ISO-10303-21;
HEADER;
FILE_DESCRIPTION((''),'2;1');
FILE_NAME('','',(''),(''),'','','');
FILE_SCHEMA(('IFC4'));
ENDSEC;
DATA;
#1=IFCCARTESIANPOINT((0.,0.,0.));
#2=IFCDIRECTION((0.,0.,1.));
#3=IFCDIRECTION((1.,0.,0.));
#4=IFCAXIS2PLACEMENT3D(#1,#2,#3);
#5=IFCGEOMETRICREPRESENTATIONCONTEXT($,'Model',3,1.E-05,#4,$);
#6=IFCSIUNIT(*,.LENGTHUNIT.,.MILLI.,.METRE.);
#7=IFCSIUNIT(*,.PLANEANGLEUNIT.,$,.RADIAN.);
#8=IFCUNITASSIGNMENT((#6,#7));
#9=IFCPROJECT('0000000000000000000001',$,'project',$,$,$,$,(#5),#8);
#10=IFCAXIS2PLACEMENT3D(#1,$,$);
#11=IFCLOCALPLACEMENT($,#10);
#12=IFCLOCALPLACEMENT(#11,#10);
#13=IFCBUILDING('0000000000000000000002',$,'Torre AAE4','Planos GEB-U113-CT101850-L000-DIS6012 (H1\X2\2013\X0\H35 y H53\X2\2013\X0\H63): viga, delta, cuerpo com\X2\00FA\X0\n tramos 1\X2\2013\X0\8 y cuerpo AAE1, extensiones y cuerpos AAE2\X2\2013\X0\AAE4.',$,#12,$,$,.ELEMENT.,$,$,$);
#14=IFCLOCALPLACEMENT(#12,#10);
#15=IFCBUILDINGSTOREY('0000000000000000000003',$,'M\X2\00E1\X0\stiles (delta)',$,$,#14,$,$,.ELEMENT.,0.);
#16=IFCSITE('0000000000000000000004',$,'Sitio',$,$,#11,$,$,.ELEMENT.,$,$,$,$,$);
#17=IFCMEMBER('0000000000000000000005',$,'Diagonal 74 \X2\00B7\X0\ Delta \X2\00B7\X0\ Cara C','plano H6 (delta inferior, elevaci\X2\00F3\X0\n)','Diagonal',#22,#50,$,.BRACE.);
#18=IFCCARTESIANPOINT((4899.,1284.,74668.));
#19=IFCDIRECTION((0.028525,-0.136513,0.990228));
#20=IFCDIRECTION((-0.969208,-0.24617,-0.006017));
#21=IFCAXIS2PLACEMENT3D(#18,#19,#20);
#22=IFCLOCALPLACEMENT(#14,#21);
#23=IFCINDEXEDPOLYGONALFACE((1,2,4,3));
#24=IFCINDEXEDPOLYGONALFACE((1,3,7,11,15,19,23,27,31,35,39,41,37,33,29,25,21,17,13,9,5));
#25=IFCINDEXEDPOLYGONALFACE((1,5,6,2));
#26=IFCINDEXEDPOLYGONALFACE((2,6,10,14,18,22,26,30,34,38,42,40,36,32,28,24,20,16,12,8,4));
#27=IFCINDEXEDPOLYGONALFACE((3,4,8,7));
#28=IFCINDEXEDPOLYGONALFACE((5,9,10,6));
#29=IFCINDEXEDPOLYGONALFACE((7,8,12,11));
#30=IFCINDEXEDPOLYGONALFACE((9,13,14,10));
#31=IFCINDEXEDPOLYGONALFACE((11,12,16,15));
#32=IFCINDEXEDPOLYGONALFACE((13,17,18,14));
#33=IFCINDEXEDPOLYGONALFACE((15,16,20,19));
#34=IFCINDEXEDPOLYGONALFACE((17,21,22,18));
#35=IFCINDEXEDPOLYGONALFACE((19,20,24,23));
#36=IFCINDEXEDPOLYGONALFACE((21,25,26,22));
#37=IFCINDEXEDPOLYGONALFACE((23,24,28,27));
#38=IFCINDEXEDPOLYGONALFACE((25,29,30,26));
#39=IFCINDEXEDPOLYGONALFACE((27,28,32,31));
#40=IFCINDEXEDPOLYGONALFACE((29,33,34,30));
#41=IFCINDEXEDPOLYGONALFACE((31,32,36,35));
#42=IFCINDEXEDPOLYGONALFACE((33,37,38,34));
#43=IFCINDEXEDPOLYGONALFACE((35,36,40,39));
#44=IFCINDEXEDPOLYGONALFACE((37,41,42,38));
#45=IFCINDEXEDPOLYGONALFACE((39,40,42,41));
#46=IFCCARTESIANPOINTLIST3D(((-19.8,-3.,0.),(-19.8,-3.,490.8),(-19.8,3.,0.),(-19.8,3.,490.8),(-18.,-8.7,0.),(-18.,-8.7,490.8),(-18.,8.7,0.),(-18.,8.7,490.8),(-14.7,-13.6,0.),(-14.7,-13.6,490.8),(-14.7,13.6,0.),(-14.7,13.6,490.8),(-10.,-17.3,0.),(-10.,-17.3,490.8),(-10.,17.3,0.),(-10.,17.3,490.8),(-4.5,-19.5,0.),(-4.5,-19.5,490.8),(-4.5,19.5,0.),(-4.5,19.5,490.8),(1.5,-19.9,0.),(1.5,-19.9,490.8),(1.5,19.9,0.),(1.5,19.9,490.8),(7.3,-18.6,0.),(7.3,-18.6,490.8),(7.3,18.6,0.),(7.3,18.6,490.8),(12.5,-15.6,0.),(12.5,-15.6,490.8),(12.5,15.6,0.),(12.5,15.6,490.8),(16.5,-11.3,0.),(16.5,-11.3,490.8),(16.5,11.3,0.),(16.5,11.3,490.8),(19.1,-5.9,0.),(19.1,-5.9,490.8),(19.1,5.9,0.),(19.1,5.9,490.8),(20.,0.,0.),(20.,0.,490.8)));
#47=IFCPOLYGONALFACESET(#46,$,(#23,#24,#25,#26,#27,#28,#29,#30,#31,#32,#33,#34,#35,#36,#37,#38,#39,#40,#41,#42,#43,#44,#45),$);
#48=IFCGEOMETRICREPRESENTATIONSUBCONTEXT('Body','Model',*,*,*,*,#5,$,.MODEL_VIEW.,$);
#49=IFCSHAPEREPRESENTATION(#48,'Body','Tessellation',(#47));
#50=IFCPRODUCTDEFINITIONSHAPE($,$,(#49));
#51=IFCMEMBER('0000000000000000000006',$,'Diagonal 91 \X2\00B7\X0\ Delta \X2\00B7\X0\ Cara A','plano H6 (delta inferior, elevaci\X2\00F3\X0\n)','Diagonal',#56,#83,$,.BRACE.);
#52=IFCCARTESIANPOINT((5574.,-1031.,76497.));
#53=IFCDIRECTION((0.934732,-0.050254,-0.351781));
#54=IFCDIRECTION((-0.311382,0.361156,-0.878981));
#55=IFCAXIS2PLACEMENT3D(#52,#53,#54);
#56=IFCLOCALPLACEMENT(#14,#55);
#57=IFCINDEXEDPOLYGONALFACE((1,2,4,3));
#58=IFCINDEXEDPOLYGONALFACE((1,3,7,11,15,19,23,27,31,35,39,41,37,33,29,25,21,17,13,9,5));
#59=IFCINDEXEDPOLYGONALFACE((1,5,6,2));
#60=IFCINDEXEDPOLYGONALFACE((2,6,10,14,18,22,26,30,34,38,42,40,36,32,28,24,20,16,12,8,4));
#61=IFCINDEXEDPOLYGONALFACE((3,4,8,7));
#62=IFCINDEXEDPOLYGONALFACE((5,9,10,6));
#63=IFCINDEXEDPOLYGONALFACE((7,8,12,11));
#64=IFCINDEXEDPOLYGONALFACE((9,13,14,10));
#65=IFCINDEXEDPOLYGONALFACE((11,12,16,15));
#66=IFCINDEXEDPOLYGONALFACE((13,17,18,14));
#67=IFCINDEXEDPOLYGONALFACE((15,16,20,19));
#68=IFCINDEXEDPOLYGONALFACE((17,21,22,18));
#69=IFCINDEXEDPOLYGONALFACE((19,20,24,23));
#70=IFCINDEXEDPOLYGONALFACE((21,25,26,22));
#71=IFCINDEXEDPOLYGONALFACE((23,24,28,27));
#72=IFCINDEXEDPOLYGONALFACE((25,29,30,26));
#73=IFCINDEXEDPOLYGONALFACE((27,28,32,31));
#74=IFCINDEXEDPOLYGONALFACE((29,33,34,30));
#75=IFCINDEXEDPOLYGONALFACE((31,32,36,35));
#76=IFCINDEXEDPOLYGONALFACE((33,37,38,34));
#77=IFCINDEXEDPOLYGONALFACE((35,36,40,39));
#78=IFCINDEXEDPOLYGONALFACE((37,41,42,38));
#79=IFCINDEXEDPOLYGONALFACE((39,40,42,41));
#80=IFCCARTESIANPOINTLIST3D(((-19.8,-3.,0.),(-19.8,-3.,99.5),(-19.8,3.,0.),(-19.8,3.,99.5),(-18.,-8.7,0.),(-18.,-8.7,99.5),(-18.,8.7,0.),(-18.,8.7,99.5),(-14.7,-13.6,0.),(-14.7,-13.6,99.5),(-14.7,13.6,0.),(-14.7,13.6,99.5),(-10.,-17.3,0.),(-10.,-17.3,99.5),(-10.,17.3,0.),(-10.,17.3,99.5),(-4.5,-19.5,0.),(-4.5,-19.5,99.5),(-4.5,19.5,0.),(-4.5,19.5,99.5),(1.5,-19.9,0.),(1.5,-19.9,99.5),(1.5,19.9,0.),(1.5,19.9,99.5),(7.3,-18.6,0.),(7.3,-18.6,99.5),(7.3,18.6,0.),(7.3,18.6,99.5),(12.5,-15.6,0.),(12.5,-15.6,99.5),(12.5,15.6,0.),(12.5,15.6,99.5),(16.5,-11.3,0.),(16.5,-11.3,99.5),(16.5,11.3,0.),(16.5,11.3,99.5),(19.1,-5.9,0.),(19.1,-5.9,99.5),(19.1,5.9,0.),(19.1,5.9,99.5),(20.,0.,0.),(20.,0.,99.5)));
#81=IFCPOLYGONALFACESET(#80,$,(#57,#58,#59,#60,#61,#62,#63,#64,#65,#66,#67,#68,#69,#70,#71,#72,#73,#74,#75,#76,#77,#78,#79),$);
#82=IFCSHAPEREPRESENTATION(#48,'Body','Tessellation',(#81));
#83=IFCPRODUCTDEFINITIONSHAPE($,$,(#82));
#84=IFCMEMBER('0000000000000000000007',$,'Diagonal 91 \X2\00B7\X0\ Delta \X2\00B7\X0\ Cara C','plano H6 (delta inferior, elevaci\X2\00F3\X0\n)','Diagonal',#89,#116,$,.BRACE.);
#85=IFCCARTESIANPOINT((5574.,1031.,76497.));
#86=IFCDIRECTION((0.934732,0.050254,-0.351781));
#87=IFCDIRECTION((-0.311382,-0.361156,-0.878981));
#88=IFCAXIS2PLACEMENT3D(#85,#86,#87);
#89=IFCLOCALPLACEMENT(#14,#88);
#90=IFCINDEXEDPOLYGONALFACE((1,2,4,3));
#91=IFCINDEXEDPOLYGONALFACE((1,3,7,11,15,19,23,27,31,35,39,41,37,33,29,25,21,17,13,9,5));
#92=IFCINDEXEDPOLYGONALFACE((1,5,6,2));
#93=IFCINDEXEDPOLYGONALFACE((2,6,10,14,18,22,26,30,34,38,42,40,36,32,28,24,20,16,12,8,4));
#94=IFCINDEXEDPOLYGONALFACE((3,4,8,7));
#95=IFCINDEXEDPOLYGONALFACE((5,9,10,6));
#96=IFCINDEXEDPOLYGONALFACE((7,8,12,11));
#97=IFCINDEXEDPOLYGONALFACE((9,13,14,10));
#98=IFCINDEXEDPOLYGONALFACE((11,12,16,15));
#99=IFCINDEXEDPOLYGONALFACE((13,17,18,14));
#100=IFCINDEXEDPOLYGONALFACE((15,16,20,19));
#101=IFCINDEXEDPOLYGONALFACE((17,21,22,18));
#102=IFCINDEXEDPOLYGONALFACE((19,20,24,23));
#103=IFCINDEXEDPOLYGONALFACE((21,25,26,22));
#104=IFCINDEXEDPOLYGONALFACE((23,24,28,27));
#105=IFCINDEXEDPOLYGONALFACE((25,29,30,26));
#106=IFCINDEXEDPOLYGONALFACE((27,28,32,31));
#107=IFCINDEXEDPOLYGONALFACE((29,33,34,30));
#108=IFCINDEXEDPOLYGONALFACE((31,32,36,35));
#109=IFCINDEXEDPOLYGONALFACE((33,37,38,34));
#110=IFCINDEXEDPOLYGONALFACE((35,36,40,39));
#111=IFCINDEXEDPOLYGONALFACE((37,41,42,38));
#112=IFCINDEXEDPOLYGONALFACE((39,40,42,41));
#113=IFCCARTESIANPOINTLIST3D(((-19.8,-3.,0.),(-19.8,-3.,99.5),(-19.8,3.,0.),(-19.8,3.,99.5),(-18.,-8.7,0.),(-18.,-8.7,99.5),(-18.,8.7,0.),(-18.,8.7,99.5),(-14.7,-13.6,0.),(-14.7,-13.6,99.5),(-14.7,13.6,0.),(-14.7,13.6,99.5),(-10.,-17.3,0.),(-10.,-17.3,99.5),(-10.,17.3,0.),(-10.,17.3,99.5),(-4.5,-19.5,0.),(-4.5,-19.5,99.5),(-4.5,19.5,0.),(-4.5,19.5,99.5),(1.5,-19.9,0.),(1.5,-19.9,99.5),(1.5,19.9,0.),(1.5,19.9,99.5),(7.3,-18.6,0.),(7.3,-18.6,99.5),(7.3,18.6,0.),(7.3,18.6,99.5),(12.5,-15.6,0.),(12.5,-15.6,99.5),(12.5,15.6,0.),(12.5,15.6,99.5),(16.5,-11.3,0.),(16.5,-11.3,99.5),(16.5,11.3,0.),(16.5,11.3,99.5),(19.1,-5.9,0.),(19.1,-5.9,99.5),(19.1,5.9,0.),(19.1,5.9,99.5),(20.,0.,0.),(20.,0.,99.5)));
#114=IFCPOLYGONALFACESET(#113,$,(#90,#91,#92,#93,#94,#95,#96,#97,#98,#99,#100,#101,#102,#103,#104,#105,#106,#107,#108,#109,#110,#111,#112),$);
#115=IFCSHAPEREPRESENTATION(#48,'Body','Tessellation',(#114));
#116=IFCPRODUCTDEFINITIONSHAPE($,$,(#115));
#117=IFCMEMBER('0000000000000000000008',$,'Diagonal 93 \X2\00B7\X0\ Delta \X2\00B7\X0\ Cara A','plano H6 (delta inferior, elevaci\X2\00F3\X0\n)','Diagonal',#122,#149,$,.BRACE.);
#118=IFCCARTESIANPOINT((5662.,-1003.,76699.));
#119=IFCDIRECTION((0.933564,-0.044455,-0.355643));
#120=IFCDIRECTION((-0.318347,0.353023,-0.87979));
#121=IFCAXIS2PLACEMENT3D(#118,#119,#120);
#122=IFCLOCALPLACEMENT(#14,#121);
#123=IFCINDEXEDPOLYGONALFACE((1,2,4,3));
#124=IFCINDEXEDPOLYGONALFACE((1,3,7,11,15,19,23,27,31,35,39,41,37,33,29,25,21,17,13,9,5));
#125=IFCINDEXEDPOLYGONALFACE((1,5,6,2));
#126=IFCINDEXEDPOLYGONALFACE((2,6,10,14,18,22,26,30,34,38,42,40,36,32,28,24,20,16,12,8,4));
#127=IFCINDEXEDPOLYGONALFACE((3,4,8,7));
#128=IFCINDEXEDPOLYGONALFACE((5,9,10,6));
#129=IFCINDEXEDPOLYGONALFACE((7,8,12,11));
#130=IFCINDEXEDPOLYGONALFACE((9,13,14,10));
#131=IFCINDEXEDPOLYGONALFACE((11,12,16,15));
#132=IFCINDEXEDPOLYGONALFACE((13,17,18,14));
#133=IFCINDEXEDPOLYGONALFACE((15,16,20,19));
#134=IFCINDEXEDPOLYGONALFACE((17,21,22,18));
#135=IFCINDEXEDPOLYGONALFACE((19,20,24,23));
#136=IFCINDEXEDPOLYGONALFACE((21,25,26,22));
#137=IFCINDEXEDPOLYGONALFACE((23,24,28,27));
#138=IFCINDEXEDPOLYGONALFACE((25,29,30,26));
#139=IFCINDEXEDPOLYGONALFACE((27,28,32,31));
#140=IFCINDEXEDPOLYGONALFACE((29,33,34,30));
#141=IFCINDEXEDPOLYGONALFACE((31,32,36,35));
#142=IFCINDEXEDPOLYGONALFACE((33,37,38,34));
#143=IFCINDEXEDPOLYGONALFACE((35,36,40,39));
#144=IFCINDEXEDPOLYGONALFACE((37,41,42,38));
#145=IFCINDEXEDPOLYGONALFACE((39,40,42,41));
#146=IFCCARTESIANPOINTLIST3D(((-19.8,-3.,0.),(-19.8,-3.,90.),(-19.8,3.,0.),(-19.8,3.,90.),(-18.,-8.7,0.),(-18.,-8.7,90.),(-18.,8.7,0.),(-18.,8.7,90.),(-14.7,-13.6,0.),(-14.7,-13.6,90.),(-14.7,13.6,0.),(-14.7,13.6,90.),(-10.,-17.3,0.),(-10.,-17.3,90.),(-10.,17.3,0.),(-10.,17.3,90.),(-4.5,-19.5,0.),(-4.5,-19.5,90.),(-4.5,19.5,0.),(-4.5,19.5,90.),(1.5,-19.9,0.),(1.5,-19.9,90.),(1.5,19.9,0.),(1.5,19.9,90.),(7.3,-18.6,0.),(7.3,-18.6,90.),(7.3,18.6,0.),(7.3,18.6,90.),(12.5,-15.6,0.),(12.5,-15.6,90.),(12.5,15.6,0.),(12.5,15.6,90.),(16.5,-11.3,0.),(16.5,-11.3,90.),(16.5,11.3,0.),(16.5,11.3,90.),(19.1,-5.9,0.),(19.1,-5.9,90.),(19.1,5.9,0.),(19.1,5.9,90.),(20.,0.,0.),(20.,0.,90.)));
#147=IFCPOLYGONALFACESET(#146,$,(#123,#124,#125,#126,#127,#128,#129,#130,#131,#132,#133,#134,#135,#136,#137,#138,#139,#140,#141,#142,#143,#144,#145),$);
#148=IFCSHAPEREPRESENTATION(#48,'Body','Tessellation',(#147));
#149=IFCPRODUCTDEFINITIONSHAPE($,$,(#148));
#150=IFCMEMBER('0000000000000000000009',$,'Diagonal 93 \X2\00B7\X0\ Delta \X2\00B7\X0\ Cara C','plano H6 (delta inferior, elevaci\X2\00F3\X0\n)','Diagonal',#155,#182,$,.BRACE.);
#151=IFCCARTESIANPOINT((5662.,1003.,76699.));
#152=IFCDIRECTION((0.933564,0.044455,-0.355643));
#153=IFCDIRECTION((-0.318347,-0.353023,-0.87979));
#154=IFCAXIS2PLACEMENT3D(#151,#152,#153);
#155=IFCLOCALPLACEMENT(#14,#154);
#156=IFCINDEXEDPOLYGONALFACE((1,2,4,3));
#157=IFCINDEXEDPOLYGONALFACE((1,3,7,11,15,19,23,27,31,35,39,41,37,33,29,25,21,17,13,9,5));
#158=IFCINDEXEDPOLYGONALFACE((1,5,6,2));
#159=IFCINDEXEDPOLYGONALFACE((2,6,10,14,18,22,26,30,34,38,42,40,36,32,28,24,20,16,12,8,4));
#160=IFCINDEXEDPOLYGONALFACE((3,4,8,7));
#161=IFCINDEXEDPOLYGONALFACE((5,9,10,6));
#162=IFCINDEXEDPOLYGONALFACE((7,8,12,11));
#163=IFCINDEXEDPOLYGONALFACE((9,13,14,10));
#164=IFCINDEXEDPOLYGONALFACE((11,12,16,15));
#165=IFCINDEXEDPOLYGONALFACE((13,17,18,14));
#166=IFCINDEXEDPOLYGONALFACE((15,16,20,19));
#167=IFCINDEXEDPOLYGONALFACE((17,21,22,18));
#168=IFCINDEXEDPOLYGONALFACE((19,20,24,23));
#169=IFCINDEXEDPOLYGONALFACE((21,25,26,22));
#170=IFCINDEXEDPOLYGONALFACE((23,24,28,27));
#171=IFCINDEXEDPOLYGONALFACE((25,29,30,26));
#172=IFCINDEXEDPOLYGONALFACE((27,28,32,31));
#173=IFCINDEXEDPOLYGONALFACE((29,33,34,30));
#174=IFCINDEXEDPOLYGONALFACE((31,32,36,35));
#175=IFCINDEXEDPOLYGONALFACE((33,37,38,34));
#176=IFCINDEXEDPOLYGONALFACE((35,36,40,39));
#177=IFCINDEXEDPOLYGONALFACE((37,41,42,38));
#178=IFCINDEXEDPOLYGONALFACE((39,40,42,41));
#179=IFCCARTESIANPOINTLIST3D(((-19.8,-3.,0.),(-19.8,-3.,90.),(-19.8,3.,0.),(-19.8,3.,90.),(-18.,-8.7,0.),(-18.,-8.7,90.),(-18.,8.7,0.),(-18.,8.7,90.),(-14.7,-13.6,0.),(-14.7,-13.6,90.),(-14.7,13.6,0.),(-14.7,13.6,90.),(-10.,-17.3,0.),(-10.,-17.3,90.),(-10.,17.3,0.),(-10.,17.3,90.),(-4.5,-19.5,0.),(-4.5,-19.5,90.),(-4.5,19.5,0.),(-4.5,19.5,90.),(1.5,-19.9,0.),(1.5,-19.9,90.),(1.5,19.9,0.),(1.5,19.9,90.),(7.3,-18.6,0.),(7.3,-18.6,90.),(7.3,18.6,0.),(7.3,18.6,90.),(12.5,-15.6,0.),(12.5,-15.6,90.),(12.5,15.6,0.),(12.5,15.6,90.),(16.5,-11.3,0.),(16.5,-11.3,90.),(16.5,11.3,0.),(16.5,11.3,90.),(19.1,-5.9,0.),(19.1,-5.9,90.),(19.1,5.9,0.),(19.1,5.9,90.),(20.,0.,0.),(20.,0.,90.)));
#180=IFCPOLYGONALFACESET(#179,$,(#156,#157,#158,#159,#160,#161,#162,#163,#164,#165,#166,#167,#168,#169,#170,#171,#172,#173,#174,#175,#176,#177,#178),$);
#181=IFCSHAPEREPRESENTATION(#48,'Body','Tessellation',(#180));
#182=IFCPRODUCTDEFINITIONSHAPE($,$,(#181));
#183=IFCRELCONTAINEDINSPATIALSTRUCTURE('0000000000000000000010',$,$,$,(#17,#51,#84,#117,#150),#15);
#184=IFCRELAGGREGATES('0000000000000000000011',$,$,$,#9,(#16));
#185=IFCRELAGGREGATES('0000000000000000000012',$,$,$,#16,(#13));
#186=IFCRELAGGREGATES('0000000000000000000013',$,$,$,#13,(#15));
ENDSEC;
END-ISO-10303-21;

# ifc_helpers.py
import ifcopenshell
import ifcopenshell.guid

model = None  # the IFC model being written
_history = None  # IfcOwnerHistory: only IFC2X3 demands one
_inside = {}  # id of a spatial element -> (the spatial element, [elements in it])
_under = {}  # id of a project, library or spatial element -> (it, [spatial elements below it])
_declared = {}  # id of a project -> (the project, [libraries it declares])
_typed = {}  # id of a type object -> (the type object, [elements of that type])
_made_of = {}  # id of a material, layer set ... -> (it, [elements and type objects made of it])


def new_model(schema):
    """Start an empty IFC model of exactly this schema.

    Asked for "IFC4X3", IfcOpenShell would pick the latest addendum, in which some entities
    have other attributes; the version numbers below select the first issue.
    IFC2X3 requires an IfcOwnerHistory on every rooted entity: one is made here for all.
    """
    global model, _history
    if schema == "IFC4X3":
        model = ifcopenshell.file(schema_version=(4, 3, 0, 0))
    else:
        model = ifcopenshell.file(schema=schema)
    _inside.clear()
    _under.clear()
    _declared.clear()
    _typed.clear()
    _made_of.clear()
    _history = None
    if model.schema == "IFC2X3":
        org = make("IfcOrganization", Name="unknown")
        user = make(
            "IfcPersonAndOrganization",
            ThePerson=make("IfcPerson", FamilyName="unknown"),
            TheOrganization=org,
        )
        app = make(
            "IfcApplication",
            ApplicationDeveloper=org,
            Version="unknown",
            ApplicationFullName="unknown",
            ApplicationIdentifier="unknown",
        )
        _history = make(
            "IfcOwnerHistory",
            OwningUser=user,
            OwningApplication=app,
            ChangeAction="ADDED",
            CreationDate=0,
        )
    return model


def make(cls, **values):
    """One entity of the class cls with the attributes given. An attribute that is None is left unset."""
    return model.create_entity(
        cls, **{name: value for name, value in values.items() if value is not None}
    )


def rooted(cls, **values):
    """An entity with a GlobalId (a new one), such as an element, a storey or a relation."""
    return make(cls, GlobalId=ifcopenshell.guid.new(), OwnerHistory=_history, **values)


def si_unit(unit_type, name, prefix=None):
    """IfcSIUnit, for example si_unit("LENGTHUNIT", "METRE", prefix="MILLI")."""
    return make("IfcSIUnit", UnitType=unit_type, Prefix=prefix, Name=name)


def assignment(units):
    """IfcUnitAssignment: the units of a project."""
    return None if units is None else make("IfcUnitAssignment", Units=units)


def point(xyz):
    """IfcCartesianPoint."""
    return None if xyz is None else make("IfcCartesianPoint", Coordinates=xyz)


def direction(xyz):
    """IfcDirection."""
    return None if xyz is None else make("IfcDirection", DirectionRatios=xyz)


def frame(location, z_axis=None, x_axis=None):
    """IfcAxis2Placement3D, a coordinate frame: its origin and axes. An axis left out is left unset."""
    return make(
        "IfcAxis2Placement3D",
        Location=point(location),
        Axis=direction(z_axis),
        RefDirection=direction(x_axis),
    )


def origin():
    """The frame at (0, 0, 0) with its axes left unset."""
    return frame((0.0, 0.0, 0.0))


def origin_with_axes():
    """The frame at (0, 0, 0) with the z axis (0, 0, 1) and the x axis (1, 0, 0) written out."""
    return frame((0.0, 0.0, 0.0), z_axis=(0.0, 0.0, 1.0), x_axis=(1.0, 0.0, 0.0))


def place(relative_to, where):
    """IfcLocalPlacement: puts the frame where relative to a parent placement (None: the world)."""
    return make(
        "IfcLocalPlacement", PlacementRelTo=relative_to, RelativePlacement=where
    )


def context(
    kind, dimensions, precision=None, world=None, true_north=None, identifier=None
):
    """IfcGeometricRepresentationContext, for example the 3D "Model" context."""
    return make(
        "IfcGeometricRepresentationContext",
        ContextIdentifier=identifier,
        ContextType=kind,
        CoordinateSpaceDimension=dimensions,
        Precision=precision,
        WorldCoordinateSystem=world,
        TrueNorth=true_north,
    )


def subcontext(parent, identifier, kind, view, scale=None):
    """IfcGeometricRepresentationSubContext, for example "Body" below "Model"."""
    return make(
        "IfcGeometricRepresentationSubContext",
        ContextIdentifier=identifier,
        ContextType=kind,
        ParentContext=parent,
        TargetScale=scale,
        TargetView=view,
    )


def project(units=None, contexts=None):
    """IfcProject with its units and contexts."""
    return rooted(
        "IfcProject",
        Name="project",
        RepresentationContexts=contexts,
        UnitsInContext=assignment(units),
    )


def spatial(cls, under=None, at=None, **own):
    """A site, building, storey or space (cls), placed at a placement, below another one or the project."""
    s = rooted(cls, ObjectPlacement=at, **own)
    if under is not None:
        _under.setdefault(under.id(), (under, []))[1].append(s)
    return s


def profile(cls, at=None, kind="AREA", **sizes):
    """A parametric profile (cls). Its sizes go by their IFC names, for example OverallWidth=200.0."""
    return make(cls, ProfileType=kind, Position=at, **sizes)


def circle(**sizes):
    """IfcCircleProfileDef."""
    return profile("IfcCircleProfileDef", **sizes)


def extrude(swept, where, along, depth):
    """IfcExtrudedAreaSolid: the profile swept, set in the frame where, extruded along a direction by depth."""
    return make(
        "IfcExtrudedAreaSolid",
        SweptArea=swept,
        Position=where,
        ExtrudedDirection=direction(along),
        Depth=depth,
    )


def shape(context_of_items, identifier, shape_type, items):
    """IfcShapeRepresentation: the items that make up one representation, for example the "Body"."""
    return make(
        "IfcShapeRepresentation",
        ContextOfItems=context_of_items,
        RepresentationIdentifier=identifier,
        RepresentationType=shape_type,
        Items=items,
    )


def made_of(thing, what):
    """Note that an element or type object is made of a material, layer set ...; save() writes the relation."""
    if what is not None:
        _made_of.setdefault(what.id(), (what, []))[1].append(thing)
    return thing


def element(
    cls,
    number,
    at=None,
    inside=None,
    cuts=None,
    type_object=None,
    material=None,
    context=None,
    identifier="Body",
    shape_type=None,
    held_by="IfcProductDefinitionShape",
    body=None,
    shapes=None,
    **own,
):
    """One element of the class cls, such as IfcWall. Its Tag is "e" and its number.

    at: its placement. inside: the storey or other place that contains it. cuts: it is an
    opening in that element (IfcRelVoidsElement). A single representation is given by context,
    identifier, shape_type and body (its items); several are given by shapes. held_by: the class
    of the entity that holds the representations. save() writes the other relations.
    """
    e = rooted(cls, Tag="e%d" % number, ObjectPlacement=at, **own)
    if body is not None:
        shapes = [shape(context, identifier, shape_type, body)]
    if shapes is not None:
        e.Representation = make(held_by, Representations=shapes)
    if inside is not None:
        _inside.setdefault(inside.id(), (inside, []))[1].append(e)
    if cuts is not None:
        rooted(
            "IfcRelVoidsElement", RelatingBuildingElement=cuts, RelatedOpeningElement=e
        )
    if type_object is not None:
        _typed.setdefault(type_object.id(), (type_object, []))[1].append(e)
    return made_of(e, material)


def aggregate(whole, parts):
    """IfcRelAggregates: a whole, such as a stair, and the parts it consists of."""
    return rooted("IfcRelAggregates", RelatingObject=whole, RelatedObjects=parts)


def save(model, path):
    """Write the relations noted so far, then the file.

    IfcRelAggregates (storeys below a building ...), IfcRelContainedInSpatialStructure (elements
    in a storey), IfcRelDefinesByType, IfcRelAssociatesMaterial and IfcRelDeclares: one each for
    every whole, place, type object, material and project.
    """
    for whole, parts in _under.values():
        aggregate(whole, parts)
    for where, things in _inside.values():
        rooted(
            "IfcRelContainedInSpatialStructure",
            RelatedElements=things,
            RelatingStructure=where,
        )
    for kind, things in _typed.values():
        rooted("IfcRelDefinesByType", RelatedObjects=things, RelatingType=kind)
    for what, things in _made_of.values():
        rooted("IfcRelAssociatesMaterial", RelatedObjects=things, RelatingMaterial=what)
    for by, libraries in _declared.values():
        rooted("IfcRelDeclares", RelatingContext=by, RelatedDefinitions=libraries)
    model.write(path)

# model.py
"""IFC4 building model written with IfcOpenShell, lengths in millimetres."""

from ifc_helpers import new_model, si_unit, frame, origin, origin_with_axes, place, context, subcontext, project, spatial, circle, extrude, element, save


model = new_model("IFC4")

# Units and contexts
model_context = context("Model", 3, precision=1e-05, world=origin_with_axes())
body_context = subcontext(model_context, "Body", "Model", "MODEL_VIEW")
ifc_project = project(units=[si_unit("LENGTHUNIT", "METRE", prefix="MILLI"), si_unit("PLANEANGLEUNIT", "RADIAN")], contexts=[model_context])

# Site, building, storey
site_placement = place(None, origin())
site = spatial("IfcSite", under=ifc_project, at=site_placement, Name="Sitio", CompositionType="ELEMENT")
building_placement = place(site_placement, origin())
building = spatial("IfcBuilding", under=site, at=building_placement, Name="Torre AAE4", Description="Planos GEB-U113-CT101850-L000-DIS6012 (H1–H35 y H53–H63): viga, delta, cuerpo común tramos 1–8 y cuerpo AAE1, extensiones y cuerpos AAE2–AAE4.", CompositionType="ELEMENT")
storey_placement = place(building_placement, origin())
storey = spatial("IfcBuildingStorey", under=building, at=storey_placement, Name="Mástiles (delta)", CompositionType="ELEMENT", Elevation=0.0)

# Members
for number, where, z_axis, x_axis, name in (
    (1, (4899.0, 1284.0, 74668.0), (0.028525, -0.136513, 0.990228), (-0.969208, -0.24617, -0.006017), "Diagonal 74 · Delta · Cara C"),
):
    element("IfcMember", number, at=place(storey_placement, frame(where, z_axis=z_axis, x_axis=x_axis)), inside=storey, Name=name, Description="plano H6 (delta inferior, elevación)", ObjectType="Diagonal", PredefinedType="BRACE", context=body_context, shape_type="SweptSolid", body=[
        extrude(circle(Radius=20.0), None, (0.0, 0.0, 1.0), 490.8),
    ])
for number, where, z_axis, x_axis, name in (
    (2, (5574.0, -1031.0, 76497.0), (0.934732, -0.050254, -0.351781), (-0.311382, 0.361156, -0.878981), "Diagonal 91 · Delta · Cara A"),
    (3, (5574.0, 1031.0, 76497.0), (0.934732, 0.050254, -0.351781), (-0.311382, -0.361156, -0.878981), "Diagonal 91 · Delta · Cara C"),
):
    element("IfcMember", number, at=place(storey_placement, frame(where, z_axis=z_axis, x_axis=x_axis)), inside=storey, Name=name, Description="plano H6 (delta inferior, elevación)", ObjectType="Diagonal", PredefinedType="BRACE", context=body_context, shape_type="SweptSolid", body=[
        extrude(circle(Radius=20.0), None, (0.0, 0.0, 1.0), 99.5),
    ])
for number, where, z_axis, x_axis, name in (
    (4, (5662.0, -1003.0, 76699.0), (0.933564, -0.044455, -0.355643), (-0.318347, 0.353023, -0.87979), "Diagonal 93 · Delta · Cara A"),
    (5, (5662.0, 1003.0, 76699.0), (0.933564, 0.044455, -0.355643), (-0.318347, -0.353023, -0.87979), "Diagonal 93 · Delta · Cara C"),
):
    element("IfcMember", number, at=place(storey_placement, frame(where, z_axis=z_axis, x_axis=x_axis)), inside=storey, Name=name, Description="plano H6 (delta inferior, elevación)", ObjectType="Diagonal", PredefinedType="BRACE", context=body_context, shape_type="SweptSolid", body=[
        extrude(circle(Radius=20.0), None, (0.0, 0.0, 1.0), 90.0),
    ])

save(model, "model.ifc")
